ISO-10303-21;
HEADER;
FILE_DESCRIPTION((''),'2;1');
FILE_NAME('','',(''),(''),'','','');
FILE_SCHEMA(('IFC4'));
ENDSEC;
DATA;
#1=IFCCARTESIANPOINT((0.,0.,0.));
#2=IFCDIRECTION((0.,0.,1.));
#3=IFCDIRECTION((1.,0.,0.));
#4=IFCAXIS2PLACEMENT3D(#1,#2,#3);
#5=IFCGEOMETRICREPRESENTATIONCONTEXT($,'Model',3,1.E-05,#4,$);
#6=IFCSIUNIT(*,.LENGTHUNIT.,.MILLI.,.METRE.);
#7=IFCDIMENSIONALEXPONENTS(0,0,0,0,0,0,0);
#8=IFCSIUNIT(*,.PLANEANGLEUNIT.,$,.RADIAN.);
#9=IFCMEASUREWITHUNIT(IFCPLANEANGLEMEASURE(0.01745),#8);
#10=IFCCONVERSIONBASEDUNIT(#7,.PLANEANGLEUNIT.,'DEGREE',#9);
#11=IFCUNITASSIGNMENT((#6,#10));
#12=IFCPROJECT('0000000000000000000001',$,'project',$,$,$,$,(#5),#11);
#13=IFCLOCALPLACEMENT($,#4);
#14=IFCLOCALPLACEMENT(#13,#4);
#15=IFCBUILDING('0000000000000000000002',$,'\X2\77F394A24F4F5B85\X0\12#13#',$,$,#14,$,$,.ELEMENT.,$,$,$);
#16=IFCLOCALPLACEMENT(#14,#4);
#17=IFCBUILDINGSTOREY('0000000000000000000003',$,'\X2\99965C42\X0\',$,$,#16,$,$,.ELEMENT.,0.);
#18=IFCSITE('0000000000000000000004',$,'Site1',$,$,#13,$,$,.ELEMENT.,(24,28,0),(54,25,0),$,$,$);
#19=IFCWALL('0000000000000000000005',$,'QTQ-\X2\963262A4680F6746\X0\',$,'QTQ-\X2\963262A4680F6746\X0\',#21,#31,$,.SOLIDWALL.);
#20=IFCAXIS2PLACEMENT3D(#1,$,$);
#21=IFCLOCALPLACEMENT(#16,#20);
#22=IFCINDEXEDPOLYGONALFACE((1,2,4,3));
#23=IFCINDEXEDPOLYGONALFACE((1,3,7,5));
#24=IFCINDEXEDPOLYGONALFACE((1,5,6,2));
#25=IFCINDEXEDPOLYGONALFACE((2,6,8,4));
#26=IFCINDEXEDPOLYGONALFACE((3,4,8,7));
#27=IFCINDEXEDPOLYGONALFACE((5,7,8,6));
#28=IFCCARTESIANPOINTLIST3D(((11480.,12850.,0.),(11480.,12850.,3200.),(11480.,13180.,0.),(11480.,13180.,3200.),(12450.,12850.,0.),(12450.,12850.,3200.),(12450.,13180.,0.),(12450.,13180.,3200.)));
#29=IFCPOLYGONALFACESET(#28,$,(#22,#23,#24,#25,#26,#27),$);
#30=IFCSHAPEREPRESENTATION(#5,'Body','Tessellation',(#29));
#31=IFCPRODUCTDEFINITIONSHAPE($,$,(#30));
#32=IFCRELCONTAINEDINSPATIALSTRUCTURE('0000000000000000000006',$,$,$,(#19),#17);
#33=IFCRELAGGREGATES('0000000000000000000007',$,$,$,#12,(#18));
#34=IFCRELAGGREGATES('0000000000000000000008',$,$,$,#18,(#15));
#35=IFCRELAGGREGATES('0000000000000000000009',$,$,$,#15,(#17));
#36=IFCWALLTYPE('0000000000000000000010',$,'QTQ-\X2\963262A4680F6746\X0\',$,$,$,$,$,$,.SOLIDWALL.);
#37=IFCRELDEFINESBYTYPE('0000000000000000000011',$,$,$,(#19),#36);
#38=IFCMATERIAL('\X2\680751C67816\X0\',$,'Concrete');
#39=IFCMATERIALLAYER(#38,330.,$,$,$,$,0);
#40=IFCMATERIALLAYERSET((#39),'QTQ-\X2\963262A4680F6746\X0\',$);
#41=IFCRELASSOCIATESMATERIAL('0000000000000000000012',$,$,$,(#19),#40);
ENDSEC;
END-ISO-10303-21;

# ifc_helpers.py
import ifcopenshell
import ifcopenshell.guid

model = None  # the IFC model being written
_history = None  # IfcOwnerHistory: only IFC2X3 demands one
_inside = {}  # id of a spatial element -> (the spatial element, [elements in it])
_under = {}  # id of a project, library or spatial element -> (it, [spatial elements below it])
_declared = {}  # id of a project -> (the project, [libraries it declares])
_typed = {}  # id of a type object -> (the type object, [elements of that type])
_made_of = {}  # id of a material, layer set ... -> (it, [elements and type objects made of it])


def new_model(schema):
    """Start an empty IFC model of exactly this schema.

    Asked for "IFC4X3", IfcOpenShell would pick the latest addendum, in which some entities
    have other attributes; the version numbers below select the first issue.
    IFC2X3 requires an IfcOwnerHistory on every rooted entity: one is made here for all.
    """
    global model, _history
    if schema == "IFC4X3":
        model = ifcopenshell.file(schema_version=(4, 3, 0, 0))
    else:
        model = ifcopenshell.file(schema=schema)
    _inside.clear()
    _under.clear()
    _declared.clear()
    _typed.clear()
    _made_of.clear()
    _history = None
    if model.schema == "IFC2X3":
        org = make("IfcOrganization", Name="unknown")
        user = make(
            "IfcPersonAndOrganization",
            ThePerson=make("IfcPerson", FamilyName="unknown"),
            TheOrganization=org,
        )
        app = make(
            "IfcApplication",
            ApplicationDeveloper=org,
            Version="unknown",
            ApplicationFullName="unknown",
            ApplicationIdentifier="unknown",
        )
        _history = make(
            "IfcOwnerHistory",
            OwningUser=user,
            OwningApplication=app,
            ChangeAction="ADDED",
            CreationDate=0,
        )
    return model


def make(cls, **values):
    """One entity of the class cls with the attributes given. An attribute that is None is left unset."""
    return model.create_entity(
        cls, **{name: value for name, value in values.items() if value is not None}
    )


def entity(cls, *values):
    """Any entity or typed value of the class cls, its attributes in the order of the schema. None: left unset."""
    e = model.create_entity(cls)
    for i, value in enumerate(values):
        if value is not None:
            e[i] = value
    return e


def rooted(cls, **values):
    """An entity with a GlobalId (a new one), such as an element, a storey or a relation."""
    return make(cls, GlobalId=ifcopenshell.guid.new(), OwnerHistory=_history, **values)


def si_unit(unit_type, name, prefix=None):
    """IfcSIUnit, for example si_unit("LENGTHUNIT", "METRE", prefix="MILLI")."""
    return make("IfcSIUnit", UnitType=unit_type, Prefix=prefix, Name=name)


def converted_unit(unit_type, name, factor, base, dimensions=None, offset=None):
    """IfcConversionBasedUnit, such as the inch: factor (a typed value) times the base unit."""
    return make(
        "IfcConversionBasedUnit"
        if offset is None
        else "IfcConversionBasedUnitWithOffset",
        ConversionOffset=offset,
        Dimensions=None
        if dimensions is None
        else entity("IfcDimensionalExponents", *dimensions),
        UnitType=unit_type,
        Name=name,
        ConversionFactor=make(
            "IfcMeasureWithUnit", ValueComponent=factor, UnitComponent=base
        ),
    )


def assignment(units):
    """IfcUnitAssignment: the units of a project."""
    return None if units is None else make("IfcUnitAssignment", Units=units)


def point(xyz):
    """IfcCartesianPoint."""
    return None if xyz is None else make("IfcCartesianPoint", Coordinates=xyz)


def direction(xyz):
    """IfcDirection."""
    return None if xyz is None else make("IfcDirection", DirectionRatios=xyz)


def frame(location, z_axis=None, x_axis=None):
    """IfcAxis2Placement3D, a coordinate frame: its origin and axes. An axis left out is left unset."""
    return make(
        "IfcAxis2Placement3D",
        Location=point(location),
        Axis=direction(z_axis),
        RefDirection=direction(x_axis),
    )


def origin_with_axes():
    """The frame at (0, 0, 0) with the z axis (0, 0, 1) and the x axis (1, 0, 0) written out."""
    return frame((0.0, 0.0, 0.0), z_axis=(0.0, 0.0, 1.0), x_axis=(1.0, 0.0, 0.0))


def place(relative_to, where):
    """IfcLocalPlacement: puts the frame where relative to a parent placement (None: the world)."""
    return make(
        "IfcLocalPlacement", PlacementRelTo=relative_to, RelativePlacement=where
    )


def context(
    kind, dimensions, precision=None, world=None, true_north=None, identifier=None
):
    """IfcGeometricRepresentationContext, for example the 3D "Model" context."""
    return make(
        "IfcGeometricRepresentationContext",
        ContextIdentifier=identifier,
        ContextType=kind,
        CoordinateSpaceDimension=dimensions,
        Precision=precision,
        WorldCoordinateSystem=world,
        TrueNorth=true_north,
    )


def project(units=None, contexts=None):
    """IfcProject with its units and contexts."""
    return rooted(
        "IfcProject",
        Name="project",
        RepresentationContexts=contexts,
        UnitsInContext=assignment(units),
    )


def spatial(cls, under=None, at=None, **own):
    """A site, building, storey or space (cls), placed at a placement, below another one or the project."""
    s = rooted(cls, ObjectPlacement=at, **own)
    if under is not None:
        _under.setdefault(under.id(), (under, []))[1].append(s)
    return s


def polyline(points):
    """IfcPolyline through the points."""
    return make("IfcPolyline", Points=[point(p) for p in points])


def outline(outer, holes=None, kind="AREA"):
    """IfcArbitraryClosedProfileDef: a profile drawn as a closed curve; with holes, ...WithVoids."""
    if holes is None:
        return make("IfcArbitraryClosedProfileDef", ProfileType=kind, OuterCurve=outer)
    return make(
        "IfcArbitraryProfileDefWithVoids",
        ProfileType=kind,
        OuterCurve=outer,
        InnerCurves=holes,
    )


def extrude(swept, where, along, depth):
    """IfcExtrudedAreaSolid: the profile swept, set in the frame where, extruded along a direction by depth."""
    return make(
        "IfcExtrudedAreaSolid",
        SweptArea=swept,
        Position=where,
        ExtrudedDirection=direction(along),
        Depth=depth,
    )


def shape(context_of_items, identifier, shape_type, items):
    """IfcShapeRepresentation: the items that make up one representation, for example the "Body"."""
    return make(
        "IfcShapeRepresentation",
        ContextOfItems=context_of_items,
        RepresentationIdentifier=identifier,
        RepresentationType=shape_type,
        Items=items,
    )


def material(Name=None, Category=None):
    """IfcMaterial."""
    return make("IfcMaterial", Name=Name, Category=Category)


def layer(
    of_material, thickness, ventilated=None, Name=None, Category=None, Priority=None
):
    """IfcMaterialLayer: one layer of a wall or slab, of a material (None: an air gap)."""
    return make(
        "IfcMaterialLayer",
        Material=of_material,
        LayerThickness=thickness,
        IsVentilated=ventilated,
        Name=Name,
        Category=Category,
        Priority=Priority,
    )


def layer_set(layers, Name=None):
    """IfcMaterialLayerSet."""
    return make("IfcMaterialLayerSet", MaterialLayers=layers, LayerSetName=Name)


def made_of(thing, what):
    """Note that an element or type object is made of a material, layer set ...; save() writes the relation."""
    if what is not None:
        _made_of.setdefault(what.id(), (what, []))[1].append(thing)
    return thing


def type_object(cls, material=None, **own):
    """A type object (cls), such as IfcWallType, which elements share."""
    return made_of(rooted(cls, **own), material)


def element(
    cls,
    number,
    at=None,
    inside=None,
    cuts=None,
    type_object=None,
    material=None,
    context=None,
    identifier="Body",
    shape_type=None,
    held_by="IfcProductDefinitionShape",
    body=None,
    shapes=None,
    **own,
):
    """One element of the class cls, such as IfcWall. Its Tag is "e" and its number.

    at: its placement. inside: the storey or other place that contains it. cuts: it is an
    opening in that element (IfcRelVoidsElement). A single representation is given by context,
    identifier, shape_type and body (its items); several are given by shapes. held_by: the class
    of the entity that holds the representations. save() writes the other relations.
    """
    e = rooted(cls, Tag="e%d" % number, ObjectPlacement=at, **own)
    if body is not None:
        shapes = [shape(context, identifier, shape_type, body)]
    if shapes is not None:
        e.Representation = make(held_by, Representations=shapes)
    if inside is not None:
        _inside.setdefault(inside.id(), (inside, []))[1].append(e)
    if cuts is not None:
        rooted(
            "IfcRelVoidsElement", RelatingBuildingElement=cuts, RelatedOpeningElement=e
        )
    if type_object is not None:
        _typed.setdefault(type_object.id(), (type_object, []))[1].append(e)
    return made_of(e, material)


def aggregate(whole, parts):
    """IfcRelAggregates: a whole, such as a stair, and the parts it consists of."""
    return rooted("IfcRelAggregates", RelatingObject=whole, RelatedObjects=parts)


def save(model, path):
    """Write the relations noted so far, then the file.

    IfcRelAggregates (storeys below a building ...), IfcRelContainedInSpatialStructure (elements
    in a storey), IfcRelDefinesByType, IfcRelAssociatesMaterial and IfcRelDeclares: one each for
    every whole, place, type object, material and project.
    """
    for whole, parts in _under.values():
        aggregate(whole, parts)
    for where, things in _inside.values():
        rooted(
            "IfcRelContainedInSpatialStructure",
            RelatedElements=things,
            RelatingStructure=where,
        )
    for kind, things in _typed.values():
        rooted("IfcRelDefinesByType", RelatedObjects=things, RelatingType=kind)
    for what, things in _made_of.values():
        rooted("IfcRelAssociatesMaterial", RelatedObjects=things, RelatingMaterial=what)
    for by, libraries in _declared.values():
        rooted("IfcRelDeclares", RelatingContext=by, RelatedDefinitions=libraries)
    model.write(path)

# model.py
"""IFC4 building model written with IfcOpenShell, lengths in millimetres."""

from ifc_helpers import new_model, entity, si_unit, converted_unit, frame, origin_with_axes, place, context, project, spatial, polyline, outline, extrude, material, layer, layer_set, type_object, element, save


model = new_model("IFC4")

# Units and contexts
model_context = context("Model", 3, precision=1e-05, world=origin_with_axes())
ifc_project = project(units=[si_unit("LENGTHUNIT", "METRE", prefix="MILLI"), converted_unit("PLANEANGLEUNIT", "DEGREE", entity("IfcPlaneAngleMeasure", 0.01745), si_unit("PLANEANGLEUNIT", "RADIAN"), dimensions=[0, 0, 0, 0, 0, 0, 0])], contexts=[model_context])

# Site, building, storey
site_placement = place(None, origin_with_axes())
site = spatial("IfcSite", under=ifc_project, at=site_placement, Name="Site1", CompositionType="ELEMENT", RefLatitude=(24, 28, 0), RefLongitude=(54, 25, 0))
building_placement = place(site_placement, origin_with_axes())
building = spatial("IfcBuilding", under=site, at=building_placement, Name="石钢住宅12#13#", CompositionType="ELEMENT")
storey_placement = place(building_placement, origin_with_axes())
storey = spatial("IfcBuildingStorey", under=building, at=storey_placement, Name="首层", CompositionType="ELEMENT", Elevation=0.0)

# Shared definitions
ifc_material_1 = material(Name="标准砖", Category="Concrete")
ifc_layer_1 = layer(ifc_material_1, 330.0, Priority=0)
ifc_layer_set_1 = layer_set([ifc_layer_1], Name="QTQ-防护栏杆")
wall_type_1 = type_object("IfcWallType", Name="QTQ-防护栏杆", PredefinedType="SOLIDWALL")

# Wall
wall_1_placement = place(storey_placement, origin_with_axes())
element("IfcWall", 1, at=wall_1_placement, inside=storey, type_object=wall_type_1, material=ifc_layer_set_1, Name="QTQ-防护栏杆", ObjectType="QTQ-防护栏杆", PredefinedType="SOLIDWALL", context=model_context, shape_type="SweptSolid", body=[
    extrude(outline(polyline([(0.0, 0.0), (3200.0, 0.0), (3200.0, 970.0), (0.0, 970.0), (0.0, 0.0)])), frame((12450.0, 12850.0, 3200.0), z_axis=(0.0, 1.0, 0.0), x_axis=(0.0, 0.0, -1.0)), (0.0, 0.0, 1.0), 330.0),
])

save(model, "model.ifc")
